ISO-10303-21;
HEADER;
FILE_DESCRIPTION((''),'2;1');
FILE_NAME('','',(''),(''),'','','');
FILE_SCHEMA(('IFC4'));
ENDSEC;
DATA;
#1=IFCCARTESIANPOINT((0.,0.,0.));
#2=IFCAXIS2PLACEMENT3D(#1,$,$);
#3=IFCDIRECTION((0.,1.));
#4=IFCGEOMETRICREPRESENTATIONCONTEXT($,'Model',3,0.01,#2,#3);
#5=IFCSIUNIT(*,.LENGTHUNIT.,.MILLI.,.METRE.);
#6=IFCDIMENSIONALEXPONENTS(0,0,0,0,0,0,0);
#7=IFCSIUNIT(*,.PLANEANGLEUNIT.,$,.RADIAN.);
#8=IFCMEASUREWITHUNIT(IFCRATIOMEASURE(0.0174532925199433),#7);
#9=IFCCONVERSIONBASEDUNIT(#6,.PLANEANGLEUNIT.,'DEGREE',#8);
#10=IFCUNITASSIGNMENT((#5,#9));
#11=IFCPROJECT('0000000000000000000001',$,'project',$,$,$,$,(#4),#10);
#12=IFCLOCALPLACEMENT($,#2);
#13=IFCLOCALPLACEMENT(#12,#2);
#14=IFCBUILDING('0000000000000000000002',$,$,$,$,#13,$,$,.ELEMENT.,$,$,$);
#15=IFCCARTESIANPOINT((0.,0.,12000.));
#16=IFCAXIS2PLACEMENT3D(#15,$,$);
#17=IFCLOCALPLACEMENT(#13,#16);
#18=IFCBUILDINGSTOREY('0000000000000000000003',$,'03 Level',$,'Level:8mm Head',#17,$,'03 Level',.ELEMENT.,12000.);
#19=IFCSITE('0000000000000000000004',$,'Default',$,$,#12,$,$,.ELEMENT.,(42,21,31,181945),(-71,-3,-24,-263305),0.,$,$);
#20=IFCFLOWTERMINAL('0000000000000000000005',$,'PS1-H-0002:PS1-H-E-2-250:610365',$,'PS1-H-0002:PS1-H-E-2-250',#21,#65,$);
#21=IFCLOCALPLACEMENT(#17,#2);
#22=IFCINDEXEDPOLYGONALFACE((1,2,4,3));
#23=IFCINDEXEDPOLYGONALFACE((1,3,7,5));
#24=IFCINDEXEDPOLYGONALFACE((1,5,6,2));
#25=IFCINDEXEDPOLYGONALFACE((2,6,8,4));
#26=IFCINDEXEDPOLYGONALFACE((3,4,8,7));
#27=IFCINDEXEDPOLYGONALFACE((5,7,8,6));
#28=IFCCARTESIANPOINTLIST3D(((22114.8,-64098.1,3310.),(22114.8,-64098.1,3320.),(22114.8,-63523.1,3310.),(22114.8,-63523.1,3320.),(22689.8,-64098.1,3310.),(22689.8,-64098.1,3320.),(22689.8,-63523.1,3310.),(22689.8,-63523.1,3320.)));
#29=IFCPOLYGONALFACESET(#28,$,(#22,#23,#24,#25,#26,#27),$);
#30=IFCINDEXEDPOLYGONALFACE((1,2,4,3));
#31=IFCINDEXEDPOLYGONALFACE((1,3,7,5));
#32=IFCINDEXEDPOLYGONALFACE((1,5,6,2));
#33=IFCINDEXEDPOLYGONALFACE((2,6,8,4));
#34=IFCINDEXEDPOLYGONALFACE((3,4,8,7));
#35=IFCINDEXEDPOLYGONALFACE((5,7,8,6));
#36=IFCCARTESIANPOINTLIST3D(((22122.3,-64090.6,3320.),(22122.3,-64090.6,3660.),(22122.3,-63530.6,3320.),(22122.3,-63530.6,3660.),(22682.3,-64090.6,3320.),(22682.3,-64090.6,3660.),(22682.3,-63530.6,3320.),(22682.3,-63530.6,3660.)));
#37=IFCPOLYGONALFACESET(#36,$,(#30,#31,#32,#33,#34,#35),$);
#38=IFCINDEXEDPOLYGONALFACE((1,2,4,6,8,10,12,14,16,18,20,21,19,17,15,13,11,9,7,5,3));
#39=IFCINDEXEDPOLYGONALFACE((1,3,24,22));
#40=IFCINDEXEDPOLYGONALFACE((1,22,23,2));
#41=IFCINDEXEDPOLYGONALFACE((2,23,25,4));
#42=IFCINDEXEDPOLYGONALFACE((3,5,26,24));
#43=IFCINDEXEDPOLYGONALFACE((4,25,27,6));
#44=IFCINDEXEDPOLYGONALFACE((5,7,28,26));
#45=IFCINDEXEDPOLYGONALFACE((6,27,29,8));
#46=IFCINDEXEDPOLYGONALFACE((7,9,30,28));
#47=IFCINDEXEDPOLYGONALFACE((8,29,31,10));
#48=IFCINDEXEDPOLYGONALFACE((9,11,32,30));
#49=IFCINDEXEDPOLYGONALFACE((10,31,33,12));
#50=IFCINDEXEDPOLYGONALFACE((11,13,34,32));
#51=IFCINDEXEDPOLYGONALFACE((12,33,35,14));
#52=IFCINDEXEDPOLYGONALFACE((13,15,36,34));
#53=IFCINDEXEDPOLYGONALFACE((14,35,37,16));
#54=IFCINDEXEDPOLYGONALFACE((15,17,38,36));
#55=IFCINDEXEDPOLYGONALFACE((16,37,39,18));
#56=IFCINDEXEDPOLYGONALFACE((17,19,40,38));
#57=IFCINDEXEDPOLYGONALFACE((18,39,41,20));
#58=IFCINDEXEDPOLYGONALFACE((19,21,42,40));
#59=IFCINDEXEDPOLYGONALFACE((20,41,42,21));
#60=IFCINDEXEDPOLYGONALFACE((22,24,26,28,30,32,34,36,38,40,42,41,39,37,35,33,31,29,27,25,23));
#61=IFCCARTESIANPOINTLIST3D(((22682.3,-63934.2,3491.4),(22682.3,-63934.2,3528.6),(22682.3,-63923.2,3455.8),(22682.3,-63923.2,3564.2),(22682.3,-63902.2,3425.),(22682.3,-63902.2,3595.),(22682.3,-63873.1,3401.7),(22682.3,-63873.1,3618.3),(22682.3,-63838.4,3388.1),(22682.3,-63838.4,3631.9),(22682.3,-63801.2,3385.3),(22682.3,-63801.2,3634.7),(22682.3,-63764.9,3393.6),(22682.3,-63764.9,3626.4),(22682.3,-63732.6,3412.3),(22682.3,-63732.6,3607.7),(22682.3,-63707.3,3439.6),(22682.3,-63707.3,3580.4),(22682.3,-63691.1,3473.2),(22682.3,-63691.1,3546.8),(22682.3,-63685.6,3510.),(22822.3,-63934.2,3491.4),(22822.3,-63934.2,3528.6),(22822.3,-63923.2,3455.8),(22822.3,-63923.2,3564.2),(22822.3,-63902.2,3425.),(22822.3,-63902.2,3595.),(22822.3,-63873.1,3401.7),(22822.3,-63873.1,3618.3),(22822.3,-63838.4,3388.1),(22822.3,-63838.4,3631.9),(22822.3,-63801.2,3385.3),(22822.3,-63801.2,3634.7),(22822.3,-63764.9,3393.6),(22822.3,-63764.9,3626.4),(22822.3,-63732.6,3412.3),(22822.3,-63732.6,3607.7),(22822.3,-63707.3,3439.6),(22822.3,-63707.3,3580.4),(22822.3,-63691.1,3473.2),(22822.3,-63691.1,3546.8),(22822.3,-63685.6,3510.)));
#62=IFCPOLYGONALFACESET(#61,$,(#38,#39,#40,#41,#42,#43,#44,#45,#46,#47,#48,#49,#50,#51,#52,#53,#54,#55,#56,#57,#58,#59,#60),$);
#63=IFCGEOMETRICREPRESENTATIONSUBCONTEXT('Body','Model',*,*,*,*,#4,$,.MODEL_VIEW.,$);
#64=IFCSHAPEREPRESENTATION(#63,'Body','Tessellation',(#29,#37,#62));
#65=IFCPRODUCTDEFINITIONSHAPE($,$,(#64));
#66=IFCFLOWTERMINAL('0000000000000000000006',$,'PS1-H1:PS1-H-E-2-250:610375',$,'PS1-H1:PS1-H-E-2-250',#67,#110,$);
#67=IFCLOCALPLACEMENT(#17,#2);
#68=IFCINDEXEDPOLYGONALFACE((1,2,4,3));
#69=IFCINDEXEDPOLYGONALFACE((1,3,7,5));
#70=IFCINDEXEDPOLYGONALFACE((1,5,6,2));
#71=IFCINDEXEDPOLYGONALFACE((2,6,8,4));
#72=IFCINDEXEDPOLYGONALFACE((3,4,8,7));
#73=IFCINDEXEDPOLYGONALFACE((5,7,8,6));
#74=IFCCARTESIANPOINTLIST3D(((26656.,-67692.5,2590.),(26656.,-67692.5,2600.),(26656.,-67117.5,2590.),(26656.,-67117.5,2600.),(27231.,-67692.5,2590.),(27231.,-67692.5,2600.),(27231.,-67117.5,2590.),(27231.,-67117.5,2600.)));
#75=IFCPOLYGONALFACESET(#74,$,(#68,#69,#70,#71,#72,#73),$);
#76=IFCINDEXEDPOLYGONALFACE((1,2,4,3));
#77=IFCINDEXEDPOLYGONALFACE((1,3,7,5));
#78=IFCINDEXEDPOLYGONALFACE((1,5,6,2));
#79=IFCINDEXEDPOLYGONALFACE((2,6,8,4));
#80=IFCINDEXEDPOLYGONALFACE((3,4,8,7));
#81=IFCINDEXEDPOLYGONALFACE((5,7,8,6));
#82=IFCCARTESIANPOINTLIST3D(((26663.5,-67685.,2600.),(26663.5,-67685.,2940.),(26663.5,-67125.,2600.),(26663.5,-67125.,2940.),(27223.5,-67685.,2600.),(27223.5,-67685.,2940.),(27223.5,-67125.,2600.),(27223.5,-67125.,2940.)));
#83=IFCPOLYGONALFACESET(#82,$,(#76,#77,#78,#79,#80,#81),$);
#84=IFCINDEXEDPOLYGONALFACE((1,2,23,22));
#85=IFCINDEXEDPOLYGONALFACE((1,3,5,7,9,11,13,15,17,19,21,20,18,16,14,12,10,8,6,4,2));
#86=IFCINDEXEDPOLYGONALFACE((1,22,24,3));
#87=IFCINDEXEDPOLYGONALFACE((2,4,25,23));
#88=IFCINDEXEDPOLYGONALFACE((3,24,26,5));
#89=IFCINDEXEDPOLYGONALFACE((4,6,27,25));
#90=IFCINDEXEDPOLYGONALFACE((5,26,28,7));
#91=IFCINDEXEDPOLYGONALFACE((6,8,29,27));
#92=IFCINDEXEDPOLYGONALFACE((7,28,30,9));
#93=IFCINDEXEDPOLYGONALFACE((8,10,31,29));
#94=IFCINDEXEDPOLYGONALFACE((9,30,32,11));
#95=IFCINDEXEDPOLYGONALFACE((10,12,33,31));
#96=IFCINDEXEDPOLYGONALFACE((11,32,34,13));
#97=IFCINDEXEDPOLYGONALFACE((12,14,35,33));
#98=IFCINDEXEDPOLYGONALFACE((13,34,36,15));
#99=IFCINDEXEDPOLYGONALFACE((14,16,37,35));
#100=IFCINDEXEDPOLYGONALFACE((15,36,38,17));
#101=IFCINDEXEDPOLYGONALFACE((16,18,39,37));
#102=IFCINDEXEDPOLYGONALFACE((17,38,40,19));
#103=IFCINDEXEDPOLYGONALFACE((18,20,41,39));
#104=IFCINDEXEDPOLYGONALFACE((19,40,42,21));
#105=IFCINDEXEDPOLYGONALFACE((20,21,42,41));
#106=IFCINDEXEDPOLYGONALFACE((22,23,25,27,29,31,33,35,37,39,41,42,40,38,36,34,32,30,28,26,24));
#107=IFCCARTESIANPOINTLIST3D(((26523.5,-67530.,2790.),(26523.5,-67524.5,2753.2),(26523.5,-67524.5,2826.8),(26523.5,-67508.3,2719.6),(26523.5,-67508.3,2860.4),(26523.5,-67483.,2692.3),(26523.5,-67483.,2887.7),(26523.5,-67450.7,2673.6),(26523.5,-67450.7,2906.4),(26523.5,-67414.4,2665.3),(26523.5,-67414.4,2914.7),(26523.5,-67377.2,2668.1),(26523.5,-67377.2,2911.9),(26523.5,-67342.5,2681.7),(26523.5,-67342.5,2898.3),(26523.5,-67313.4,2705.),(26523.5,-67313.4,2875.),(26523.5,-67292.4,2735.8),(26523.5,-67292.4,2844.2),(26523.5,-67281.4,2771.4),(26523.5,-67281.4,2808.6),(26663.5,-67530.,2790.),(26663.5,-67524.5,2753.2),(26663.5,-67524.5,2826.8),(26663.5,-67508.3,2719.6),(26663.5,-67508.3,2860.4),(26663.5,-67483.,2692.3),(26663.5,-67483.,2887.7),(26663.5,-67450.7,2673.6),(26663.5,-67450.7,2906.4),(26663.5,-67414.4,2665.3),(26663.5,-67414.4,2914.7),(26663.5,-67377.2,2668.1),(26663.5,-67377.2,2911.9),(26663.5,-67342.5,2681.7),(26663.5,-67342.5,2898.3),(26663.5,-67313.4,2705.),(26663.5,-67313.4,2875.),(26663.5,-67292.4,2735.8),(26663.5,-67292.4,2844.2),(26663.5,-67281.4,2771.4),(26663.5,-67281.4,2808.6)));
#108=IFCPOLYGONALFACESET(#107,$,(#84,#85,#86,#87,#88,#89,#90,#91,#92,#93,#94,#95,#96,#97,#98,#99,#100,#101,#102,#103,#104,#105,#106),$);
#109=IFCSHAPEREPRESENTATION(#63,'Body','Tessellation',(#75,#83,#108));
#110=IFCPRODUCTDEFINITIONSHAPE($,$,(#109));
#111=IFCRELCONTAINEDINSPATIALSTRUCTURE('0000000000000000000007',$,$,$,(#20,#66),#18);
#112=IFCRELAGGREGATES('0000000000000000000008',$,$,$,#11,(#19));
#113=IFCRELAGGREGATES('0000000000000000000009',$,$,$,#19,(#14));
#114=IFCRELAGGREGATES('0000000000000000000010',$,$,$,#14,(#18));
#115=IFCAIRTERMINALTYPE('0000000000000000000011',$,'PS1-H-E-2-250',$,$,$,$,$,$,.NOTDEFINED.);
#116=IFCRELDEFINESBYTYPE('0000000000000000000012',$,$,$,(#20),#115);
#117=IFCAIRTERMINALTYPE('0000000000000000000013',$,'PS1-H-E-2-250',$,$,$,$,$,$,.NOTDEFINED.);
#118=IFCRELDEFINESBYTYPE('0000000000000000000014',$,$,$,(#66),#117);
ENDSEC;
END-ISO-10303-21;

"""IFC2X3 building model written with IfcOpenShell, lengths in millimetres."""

from ifc_helpers import new_model, entity, si_unit, converted_unit, direction, frame, frame_2d, origin, origin_2d_with_axis, place, context, subcontext, project, spatial, rectangle, circle, extrude, source, transform, mapped, type_object, type_shapes, element, save


model = new_model("IFC2X3")

# Units and contexts
model_context = context("Model", 3, precision=0.01, world=origin(), true_north=direction((0.0, 1.0)))
body_context = subcontext(model_context, "Body", "Model", "MODEL_VIEW")
ifc_project = project(units=[si_unit("LENGTHUNIT", "METRE", prefix="MILLI"), converted_unit("PLANEANGLEUNIT", "DEGREE", entity("IfcRatioMeasure", 0.0174532925199433), si_unit("PLANEANGLEUNIT", "RADIAN"), dimensions=[0, 0, 0, 0, 0, 0, 0])], contexts=[model_context])

# Site, building, storey
site_placement = place(None, origin())
site = spatial("IfcSite", under=ifc_project, at=site_placement, Name="Default", CompositionType="ELEMENT", RefLatitude=(42, 21, 31, 181945), RefLongitude=(-71, -3, -24, -263305), RefElevation=0.0)
building_placement = place(site_placement, origin())
building = spatial("IfcBuilding", under=site, at=building_placement, CompositionType="ELEMENT")
storey_placement = place(building_placement, frame((0.0, 0.0, 12000.0)))
storey = spatial("IfcBuildingStorey", under=building, at=storey_placement, Name="03 Level", ObjectType="Level:8mm Head", LongName="03 Level", CompositionType="ELEMENT", Elevation=12000.0)

# Flow terminals
air_terminal_type_1 = type_object("IfcAirTerminalType", Name="PS1-H-E-2-250", PredefinedType="NOTDEFINED")
shared_shape_1 = source(origin(), body_context, "Body", "SweptSolid", [
    extrude(rectangle(XDim=575.0, YDim=575.0, at=origin_2d_with_axis()), frame((0.0, 0.0, -10.0), z_axis=(0.0, 0.0, 1.0), x_axis=(0.0, 1.0, 0.0)), (0.0, 0.0, 1.0), 10.0),
    extrude(rectangle(XDim=560.0, YDim=560.0, at=origin_2d_with_axis()), frame((0.0, 0.0, 0.0), z_axis=(0.0, 0.0, 1.0), x_axis=(0.0, 1.0, 0.0)), (0.0, 0.0, 1.0), 340.0),
    extrude(circle(Radius=125.0, at=frame_2d((0.0, 0.0), x_axis=(1.0, 0.0))), frame((-420.0, 0.0, 190.0), z_axis=(1.0, 0.0, 0.0), x_axis=(0.0, -1.0, 0.0)), (0.0, 0.0, 1.0), 140.0),
])
type_shapes(air_terminal_type_1, [shared_shape_1])
flow_terminal_1_placement = place(storey_placement, frame((22402.3, -63810.6, 3320.0), z_axis=(0.0, 0.0, 1.0), x_axis=(-1.0, 0.0, 0.0)))
element("IfcFlowTerminal", 1, at=flow_terminal_1_placement, inside=storey, type_object=air_terminal_type_1, Name="PS1-H-0002:PS1-H-E-2-250:610365", ObjectType="PS1-H-0002:PS1-H-E-2-250", context=body_context, shape_type="MappedRepresentation", body=[
    mapped(shared_shape_1, transform((0.0, 0.0, 0.0), scale=1.0)),
])
air_terminal_type_2 = type_object("IfcAirTerminalType", Name="PS1-H-E-2-250", PredefinedType="NOTDEFINED")
shared_shape_2 = source(origin(), body_context, "Body", "SweptSolid", [
    extrude(rectangle(XDim=575.0, YDim=575.0, at=origin_2d_with_axis()), frame((0.0, 0.0, -10.0), z_axis=(0.0, 0.0, 1.0), x_axis=(0.0, 1.0, 0.0)), (0.0, 0.0, 1.0), 10.0),
    extrude(rectangle(XDim=560.0, YDim=560.0, at=origin_2d_with_axis()), frame((0.0, 0.0, 0.0), z_axis=(0.0, 0.0, 1.0), x_axis=(0.0, 1.0, 0.0)), (0.0, 0.0, 1.0), 340.0),
    extrude(circle(Radius=125.0, at=frame_2d((0.0, 0.0), x_axis=(1.0, 0.0))), frame((-420.0, 0.0, 190.0), z_axis=(1.0, 0.0, 0.0), x_axis=(0.0, -1.0, 0.0)), (0.0, 0.0, 1.0), 140.0),
])
type_shapes(air_terminal_type_2, [shared_shape_2])
flow_terminal_2_placement = place(storey_placement, frame((26943.5, -67405.0, 2600.0)))
element("IfcFlowTerminal", 2, at=flow_terminal_2_placement, inside=storey, type_object=air_terminal_type_2, Name="PS1-H1:PS1-H-E-2-250:610375", ObjectType="PS1-H1:PS1-H-E-2-250", context=body_context, shape_type="MappedRepresentation", body=[
    mapped(shared_shape_2, transform((0.0, 0.0, 0.0), scale=1.0)),
])

save(model, "model.ifc")
